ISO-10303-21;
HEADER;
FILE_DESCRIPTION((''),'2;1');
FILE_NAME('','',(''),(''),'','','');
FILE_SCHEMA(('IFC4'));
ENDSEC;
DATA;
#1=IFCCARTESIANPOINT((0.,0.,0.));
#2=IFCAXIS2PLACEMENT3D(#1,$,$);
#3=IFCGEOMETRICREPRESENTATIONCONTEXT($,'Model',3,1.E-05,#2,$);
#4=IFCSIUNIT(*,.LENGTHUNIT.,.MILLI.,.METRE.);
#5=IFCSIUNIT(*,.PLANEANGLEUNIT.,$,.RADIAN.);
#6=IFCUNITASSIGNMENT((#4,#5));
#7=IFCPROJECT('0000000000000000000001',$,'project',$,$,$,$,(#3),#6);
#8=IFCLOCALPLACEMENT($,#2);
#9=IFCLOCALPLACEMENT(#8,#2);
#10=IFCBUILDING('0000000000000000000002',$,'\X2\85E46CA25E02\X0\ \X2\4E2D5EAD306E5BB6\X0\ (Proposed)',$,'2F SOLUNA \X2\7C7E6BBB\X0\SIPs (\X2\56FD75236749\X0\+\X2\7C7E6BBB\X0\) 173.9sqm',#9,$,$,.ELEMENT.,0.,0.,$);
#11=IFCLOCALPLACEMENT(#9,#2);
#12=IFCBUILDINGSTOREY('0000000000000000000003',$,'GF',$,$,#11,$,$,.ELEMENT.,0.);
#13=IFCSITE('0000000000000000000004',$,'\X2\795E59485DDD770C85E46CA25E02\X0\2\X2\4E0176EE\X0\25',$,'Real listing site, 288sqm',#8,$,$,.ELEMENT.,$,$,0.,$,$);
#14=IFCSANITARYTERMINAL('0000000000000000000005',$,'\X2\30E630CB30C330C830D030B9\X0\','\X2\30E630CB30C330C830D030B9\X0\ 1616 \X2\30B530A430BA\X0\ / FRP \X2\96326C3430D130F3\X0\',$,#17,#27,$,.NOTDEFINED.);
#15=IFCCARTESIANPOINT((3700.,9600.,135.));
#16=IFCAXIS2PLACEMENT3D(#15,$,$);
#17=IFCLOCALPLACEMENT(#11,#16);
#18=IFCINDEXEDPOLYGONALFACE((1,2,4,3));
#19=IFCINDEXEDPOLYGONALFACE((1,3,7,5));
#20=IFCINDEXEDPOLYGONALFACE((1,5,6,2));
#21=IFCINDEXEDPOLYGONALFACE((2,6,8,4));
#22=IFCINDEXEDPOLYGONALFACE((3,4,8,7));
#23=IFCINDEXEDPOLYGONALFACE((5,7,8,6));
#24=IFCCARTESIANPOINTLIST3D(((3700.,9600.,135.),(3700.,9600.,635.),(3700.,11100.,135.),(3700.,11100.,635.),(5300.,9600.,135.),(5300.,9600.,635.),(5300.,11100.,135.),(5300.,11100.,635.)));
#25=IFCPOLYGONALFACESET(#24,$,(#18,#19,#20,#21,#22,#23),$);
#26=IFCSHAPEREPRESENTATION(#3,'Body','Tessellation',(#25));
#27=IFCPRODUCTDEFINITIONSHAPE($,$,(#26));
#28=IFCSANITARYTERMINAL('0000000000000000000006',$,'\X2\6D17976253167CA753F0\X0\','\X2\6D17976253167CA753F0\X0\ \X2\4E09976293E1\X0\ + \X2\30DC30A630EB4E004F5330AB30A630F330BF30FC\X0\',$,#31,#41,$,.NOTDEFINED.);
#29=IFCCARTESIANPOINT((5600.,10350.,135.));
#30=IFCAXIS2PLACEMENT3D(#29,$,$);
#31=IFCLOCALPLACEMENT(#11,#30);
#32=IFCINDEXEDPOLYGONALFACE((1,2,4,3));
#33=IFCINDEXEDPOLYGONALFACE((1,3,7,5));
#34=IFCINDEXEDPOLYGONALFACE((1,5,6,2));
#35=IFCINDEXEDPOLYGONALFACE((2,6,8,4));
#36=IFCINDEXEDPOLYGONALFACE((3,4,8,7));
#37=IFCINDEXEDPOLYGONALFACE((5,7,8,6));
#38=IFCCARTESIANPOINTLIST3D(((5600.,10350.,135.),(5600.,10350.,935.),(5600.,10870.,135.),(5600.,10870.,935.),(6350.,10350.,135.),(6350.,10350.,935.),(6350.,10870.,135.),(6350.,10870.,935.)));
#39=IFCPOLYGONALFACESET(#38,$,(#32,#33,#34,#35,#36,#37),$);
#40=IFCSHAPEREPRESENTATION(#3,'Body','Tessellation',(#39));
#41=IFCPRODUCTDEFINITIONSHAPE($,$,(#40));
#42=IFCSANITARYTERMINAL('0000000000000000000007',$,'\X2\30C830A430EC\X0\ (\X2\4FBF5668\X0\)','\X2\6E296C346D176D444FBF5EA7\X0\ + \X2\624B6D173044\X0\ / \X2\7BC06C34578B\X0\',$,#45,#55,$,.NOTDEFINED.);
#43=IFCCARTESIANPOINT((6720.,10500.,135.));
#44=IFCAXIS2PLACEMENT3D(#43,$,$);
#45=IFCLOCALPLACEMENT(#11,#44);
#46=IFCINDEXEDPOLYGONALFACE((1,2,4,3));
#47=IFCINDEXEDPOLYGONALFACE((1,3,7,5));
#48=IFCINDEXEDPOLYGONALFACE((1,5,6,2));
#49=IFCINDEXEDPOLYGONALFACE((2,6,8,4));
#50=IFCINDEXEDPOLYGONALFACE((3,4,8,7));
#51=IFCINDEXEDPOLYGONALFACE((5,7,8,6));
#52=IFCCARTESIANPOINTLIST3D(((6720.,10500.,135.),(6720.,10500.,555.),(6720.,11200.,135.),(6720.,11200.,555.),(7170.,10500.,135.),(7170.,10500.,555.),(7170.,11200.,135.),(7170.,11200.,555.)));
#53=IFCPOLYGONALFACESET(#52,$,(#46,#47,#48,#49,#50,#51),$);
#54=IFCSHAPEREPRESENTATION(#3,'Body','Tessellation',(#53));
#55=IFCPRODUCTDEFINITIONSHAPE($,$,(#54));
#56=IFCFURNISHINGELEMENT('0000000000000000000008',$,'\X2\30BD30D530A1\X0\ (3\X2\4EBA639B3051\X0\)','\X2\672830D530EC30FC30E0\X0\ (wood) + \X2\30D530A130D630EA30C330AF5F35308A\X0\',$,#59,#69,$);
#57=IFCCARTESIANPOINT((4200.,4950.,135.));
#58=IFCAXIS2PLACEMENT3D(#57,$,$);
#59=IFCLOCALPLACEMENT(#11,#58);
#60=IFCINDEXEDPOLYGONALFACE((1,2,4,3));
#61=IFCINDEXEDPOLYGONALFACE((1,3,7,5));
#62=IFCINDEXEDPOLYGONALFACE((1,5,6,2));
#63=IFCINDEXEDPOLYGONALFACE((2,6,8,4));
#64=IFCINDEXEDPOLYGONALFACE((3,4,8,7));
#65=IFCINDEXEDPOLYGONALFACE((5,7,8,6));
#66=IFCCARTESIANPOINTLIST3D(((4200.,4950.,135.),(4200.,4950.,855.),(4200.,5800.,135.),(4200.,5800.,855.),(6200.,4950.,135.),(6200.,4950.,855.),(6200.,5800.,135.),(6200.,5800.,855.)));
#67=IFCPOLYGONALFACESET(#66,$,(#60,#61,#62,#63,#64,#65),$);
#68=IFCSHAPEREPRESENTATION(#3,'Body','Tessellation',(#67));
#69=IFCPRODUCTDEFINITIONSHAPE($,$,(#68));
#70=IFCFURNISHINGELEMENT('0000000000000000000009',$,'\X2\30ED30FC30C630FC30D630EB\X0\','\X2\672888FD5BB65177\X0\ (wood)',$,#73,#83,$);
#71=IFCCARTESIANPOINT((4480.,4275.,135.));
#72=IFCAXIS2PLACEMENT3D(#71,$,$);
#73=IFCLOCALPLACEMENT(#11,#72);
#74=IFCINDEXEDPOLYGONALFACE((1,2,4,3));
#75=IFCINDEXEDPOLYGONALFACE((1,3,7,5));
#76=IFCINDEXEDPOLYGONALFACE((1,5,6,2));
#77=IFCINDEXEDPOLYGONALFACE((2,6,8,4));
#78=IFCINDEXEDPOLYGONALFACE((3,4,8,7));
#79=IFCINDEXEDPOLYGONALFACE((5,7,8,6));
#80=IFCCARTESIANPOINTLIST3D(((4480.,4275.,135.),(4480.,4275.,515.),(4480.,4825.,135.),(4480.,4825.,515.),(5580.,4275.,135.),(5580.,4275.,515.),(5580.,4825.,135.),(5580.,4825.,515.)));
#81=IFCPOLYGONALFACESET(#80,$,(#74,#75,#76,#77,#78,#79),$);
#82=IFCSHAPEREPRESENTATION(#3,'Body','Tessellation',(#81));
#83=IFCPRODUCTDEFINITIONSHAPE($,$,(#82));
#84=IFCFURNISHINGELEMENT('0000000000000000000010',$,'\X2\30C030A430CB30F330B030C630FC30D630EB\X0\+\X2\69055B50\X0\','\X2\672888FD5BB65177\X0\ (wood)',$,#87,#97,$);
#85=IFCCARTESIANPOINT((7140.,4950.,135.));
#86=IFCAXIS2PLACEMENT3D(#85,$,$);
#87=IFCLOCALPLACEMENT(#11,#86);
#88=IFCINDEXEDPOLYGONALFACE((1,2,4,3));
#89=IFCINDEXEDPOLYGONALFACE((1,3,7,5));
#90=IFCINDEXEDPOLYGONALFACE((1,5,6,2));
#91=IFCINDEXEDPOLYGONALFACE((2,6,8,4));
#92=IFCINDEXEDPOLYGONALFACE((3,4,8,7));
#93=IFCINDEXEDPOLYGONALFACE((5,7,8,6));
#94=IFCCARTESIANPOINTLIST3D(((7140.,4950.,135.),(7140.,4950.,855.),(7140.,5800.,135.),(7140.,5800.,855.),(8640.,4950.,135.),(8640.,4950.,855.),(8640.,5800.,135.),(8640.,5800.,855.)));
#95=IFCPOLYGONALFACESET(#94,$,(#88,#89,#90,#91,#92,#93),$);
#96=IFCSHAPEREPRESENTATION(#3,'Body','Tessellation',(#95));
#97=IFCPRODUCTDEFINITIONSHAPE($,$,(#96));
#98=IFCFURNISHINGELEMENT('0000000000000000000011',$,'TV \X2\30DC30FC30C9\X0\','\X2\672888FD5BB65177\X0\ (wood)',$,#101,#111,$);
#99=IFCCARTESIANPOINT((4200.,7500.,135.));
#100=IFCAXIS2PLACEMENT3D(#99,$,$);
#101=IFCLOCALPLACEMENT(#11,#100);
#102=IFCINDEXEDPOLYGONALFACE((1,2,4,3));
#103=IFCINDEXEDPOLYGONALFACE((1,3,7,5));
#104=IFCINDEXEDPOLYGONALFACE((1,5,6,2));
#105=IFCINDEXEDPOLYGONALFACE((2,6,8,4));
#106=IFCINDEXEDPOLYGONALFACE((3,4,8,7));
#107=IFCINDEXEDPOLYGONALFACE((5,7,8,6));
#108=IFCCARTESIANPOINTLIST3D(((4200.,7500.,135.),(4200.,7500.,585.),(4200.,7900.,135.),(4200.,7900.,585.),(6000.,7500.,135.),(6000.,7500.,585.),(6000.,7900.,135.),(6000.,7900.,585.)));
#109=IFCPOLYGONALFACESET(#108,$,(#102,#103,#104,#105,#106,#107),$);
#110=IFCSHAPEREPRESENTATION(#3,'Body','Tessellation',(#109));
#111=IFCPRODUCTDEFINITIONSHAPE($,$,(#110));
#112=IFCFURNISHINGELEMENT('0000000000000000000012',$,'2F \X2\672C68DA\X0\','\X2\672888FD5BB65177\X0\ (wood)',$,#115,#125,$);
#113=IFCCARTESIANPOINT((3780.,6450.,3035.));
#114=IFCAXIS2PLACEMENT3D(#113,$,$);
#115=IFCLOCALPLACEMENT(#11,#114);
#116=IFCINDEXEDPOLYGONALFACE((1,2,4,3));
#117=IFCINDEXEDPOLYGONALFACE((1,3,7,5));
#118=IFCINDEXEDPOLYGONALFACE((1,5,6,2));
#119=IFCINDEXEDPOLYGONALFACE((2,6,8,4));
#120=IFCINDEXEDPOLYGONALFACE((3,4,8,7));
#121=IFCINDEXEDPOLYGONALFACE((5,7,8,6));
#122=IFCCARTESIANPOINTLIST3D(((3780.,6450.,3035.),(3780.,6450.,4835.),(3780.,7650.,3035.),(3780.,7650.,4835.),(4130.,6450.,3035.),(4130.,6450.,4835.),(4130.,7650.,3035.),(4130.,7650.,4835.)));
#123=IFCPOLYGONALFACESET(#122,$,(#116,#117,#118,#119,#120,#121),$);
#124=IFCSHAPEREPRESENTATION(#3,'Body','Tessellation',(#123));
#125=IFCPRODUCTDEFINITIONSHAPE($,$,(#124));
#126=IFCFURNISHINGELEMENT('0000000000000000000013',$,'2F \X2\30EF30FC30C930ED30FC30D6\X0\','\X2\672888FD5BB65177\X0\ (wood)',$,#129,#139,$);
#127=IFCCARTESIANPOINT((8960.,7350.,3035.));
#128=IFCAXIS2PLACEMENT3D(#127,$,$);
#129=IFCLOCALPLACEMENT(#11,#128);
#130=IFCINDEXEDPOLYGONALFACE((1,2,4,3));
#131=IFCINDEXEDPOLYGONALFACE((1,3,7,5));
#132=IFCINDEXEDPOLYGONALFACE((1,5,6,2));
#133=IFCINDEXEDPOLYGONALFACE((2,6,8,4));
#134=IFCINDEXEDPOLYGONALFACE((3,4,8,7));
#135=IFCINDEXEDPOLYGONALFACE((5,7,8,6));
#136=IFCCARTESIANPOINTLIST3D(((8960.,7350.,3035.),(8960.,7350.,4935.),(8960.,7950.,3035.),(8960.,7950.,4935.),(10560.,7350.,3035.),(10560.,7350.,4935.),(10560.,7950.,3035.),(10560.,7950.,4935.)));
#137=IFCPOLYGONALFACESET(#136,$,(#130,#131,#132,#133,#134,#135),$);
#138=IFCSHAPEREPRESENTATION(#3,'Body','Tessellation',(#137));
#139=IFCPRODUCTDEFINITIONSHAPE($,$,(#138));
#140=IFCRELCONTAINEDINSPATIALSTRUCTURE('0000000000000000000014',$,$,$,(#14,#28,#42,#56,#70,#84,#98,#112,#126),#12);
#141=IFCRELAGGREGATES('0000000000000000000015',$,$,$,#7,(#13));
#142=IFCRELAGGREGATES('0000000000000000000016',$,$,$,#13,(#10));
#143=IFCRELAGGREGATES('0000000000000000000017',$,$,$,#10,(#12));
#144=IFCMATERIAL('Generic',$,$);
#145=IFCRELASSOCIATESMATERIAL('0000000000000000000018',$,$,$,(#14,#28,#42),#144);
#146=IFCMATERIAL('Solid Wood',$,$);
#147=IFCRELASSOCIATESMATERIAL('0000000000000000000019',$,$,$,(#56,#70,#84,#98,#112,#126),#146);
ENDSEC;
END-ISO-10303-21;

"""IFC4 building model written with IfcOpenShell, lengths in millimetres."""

from ifc_helpers import new_model, si_unit, frame, frame_2d, origin, place, context, project, spatial, rectangle, extrude, material, element, save


model = new_model("IFC4")

# Units and contexts
model_context = context("Model", 3, precision=1e-05, world=origin())
ifc_project = project(units=[si_unit("LENGTHUNIT", "METRE", prefix="MILLI"), si_unit("PLANEANGLEUNIT", "RADIAN")], contexts=[model_context])

# Site, building, storey
site_placement = place(None, origin())
site = spatial("IfcSite", under=ifc_project, at=site_placement, Name="神奈川県藤沢市2丁目25", ObjectType="Real listing site, 288sqm", CompositionType="ELEMENT", RefElevation=0.0)
building_placement = place(site_placement, origin())
building = spatial("IfcBuilding", under=site, at=building_placement, Name="藤沢市 中庭の家 (Proposed)", ObjectType="2F SOLUNA 籾殻SIPs (国産杉+籾殻) 173.9sqm", CompositionType="ELEMENT", ElevationOfRefHeight=0.0, ElevationOfTerrain=0.0)
storey_placement = place(building_placement, origin())
storey = spatial("IfcBuildingStorey", under=building, at=storey_placement, Name="GF", CompositionType="ELEMENT", Elevation=0.0)

# Shared definitions
ifc_material_1 = material(Name="Generic")

# Shared definitions
ifc_material_2 = material(Name="Solid Wood")

# Sanitary terminals
sanitary_terminal_1_placement = place(storey_placement, frame((3700.0, 9600.0, 135.0)))
element("IfcSanitaryTerminal", 1, at=sanitary_terminal_1_placement, inside=storey, material=ifc_material_1, Name="ユニットバス", Description="ユニットバス 1616 サイズ / FRP 防水パン", PredefinedType="NOTDEFINED", context=model_context, shape_type="SweptSolid", body=[
    extrude(rectangle(XDim=1600.0, YDim=1500.0, at=frame_2d((800.0, 750.0))), frame((3700.0, 9600.0, 135.0)), (0.0, 0.0, 1.0), 500.0),
])
sanitary_terminal_2_placement = place(storey_placement, frame((5600.0, 10350.0, 135.0)))
element("IfcSanitaryTerminal", 2, at=sanitary_terminal_2_placement, inside=storey, material=ifc_material_1, Name="洗面化粧台", Description="洗面化粧台 三面鏡 + ボウル一体カウンター", PredefinedType="NOTDEFINED", context=model_context, shape_type="SweptSolid", body=[
    extrude(rectangle(XDim=750.0, YDim=520.0, at=frame_2d((375.0, 260.0))), frame((5600.0, 10350.0, 135.0)), (0.0, 0.0, 1.0), 800.0),
])
sanitary_terminal_3_placement = place(storey_placement, frame((6720.0, 10500.0, 135.0)))
element("IfcSanitaryTerminal", 3, at=sanitary_terminal_3_placement, inside=storey, material=ifc_material_1, Name="トイレ (便器)", Description="温水洗浄便座 + 手洗い / 節水型", PredefinedType="NOTDEFINED", context=model_context, shape_type="SweptSolid", body=[
    extrude(rectangle(XDim=450.0, YDim=700.0, at=frame_2d((225.0, 350.0))), frame((6720.0, 10500.0, 135.0)), (0.0, 0.0, 1.0), 420.0),
])

# Furnishing elements
furnishing_1_placement = place(storey_placement, frame((4200.0, 4950.0, 135.0)))
element("IfcFurnishingElement", 4, at=furnishing_1_placement, inside=storey, material=ifc_material_2, Name="ソファ (3人掛け)", Description="木フレーム (wood) + ファブリック張り", context=model_context, shape_type="SweptSolid", body=[
    extrude(rectangle(XDim=2000.0, YDim=850.0, at=frame_2d((1000.0, 425.0))), frame((4200.0, 4950.0, 135.0)), (0.0, 0.0, 1.0), 720.0),
])
furnishing_2_placement = place(storey_placement, frame((4480.0, 4275.0, 135.0)))
element("IfcFurnishingElement", 5, at=furnishing_2_placement, inside=storey, material=ifc_material_2, Name="ローテーブル", Description="木製家具 (wood)", context=model_context, shape_type="SweptSolid", body=[
    extrude(rectangle(XDim=1100.0, YDim=550.0, at=frame_2d((550.0, 275.0))), frame((4480.0, 4275.0, 135.0)), (0.0, 0.0, 1.0), 380.0),
])
furnishing_3_placement = place(storey_placement, frame((7140.0, 4950.0, 135.0)))
element("IfcFurnishingElement", 6, at=furnishing_3_placement, inside=storey, material=ifc_material_2, Name="ダイニングテーブル+椅子", Description="木製家具 (wood)", context=model_context, shape_type="SweptSolid", body=[
    extrude(rectangle(XDim=1500.0, YDim=850.0, at=frame_2d((750.0, 425.0))), frame((7140.0, 4950.0, 135.0)), (0.0, 0.0, 1.0), 720.0),
])
furnishing_4_placement = place(storey_placement, frame((4200.0, 7500.0, 135.0)))
element("IfcFurnishingElement", 7, at=furnishing_4_placement, inside=storey, material=ifc_material_2, Name="TV ボード", Description="木製家具 (wood)", context=model_context, shape_type="SweptSolid", body=[
    extrude(rectangle(XDim=1800.0, YDim=400.0, at=frame_2d((900.0, 200.0))), frame((4200.0, 7500.0, 135.0)), (0.0, 0.0, 1.0), 450.0),
])
furnishing_5_placement = place(storey_placement, frame((3780.0, 6450.0, 3035.0)))
element("IfcFurnishingElement", 8, at=furnishing_5_placement, inside=storey, material=ifc_material_2, Name="2F 本棚", Description="木製家具 (wood)", context=model_context, shape_type="SweptSolid", body=[
    extrude(rectangle(XDim=350.0, YDim=1200.0, at=frame_2d((175.0, 600.0))), frame((3780.0, 6450.0, 3035.0)), (0.0, 0.0, 1.0), 1800.0),
])
furnishing_6_placement = place(storey_placement, frame((8960.0, 7350.0, 3035.0)))
element("IfcFurnishingElement", 9, at=furnishing_6_placement, inside=storey, material=ifc_material_2, Name="2F ワードローブ", Description="木製家具 (wood)", context=model_context, shape_type="SweptSolid", body=[
    extrude(rectangle(XDim=1600.0, YDim=600.0, at=frame_2d((800.0, 300.0))), frame((8960.0, 7350.0, 3035.0)), (0.0, 0.0, 1.0), 1900.0),
])

save(model, "model.ifc")
